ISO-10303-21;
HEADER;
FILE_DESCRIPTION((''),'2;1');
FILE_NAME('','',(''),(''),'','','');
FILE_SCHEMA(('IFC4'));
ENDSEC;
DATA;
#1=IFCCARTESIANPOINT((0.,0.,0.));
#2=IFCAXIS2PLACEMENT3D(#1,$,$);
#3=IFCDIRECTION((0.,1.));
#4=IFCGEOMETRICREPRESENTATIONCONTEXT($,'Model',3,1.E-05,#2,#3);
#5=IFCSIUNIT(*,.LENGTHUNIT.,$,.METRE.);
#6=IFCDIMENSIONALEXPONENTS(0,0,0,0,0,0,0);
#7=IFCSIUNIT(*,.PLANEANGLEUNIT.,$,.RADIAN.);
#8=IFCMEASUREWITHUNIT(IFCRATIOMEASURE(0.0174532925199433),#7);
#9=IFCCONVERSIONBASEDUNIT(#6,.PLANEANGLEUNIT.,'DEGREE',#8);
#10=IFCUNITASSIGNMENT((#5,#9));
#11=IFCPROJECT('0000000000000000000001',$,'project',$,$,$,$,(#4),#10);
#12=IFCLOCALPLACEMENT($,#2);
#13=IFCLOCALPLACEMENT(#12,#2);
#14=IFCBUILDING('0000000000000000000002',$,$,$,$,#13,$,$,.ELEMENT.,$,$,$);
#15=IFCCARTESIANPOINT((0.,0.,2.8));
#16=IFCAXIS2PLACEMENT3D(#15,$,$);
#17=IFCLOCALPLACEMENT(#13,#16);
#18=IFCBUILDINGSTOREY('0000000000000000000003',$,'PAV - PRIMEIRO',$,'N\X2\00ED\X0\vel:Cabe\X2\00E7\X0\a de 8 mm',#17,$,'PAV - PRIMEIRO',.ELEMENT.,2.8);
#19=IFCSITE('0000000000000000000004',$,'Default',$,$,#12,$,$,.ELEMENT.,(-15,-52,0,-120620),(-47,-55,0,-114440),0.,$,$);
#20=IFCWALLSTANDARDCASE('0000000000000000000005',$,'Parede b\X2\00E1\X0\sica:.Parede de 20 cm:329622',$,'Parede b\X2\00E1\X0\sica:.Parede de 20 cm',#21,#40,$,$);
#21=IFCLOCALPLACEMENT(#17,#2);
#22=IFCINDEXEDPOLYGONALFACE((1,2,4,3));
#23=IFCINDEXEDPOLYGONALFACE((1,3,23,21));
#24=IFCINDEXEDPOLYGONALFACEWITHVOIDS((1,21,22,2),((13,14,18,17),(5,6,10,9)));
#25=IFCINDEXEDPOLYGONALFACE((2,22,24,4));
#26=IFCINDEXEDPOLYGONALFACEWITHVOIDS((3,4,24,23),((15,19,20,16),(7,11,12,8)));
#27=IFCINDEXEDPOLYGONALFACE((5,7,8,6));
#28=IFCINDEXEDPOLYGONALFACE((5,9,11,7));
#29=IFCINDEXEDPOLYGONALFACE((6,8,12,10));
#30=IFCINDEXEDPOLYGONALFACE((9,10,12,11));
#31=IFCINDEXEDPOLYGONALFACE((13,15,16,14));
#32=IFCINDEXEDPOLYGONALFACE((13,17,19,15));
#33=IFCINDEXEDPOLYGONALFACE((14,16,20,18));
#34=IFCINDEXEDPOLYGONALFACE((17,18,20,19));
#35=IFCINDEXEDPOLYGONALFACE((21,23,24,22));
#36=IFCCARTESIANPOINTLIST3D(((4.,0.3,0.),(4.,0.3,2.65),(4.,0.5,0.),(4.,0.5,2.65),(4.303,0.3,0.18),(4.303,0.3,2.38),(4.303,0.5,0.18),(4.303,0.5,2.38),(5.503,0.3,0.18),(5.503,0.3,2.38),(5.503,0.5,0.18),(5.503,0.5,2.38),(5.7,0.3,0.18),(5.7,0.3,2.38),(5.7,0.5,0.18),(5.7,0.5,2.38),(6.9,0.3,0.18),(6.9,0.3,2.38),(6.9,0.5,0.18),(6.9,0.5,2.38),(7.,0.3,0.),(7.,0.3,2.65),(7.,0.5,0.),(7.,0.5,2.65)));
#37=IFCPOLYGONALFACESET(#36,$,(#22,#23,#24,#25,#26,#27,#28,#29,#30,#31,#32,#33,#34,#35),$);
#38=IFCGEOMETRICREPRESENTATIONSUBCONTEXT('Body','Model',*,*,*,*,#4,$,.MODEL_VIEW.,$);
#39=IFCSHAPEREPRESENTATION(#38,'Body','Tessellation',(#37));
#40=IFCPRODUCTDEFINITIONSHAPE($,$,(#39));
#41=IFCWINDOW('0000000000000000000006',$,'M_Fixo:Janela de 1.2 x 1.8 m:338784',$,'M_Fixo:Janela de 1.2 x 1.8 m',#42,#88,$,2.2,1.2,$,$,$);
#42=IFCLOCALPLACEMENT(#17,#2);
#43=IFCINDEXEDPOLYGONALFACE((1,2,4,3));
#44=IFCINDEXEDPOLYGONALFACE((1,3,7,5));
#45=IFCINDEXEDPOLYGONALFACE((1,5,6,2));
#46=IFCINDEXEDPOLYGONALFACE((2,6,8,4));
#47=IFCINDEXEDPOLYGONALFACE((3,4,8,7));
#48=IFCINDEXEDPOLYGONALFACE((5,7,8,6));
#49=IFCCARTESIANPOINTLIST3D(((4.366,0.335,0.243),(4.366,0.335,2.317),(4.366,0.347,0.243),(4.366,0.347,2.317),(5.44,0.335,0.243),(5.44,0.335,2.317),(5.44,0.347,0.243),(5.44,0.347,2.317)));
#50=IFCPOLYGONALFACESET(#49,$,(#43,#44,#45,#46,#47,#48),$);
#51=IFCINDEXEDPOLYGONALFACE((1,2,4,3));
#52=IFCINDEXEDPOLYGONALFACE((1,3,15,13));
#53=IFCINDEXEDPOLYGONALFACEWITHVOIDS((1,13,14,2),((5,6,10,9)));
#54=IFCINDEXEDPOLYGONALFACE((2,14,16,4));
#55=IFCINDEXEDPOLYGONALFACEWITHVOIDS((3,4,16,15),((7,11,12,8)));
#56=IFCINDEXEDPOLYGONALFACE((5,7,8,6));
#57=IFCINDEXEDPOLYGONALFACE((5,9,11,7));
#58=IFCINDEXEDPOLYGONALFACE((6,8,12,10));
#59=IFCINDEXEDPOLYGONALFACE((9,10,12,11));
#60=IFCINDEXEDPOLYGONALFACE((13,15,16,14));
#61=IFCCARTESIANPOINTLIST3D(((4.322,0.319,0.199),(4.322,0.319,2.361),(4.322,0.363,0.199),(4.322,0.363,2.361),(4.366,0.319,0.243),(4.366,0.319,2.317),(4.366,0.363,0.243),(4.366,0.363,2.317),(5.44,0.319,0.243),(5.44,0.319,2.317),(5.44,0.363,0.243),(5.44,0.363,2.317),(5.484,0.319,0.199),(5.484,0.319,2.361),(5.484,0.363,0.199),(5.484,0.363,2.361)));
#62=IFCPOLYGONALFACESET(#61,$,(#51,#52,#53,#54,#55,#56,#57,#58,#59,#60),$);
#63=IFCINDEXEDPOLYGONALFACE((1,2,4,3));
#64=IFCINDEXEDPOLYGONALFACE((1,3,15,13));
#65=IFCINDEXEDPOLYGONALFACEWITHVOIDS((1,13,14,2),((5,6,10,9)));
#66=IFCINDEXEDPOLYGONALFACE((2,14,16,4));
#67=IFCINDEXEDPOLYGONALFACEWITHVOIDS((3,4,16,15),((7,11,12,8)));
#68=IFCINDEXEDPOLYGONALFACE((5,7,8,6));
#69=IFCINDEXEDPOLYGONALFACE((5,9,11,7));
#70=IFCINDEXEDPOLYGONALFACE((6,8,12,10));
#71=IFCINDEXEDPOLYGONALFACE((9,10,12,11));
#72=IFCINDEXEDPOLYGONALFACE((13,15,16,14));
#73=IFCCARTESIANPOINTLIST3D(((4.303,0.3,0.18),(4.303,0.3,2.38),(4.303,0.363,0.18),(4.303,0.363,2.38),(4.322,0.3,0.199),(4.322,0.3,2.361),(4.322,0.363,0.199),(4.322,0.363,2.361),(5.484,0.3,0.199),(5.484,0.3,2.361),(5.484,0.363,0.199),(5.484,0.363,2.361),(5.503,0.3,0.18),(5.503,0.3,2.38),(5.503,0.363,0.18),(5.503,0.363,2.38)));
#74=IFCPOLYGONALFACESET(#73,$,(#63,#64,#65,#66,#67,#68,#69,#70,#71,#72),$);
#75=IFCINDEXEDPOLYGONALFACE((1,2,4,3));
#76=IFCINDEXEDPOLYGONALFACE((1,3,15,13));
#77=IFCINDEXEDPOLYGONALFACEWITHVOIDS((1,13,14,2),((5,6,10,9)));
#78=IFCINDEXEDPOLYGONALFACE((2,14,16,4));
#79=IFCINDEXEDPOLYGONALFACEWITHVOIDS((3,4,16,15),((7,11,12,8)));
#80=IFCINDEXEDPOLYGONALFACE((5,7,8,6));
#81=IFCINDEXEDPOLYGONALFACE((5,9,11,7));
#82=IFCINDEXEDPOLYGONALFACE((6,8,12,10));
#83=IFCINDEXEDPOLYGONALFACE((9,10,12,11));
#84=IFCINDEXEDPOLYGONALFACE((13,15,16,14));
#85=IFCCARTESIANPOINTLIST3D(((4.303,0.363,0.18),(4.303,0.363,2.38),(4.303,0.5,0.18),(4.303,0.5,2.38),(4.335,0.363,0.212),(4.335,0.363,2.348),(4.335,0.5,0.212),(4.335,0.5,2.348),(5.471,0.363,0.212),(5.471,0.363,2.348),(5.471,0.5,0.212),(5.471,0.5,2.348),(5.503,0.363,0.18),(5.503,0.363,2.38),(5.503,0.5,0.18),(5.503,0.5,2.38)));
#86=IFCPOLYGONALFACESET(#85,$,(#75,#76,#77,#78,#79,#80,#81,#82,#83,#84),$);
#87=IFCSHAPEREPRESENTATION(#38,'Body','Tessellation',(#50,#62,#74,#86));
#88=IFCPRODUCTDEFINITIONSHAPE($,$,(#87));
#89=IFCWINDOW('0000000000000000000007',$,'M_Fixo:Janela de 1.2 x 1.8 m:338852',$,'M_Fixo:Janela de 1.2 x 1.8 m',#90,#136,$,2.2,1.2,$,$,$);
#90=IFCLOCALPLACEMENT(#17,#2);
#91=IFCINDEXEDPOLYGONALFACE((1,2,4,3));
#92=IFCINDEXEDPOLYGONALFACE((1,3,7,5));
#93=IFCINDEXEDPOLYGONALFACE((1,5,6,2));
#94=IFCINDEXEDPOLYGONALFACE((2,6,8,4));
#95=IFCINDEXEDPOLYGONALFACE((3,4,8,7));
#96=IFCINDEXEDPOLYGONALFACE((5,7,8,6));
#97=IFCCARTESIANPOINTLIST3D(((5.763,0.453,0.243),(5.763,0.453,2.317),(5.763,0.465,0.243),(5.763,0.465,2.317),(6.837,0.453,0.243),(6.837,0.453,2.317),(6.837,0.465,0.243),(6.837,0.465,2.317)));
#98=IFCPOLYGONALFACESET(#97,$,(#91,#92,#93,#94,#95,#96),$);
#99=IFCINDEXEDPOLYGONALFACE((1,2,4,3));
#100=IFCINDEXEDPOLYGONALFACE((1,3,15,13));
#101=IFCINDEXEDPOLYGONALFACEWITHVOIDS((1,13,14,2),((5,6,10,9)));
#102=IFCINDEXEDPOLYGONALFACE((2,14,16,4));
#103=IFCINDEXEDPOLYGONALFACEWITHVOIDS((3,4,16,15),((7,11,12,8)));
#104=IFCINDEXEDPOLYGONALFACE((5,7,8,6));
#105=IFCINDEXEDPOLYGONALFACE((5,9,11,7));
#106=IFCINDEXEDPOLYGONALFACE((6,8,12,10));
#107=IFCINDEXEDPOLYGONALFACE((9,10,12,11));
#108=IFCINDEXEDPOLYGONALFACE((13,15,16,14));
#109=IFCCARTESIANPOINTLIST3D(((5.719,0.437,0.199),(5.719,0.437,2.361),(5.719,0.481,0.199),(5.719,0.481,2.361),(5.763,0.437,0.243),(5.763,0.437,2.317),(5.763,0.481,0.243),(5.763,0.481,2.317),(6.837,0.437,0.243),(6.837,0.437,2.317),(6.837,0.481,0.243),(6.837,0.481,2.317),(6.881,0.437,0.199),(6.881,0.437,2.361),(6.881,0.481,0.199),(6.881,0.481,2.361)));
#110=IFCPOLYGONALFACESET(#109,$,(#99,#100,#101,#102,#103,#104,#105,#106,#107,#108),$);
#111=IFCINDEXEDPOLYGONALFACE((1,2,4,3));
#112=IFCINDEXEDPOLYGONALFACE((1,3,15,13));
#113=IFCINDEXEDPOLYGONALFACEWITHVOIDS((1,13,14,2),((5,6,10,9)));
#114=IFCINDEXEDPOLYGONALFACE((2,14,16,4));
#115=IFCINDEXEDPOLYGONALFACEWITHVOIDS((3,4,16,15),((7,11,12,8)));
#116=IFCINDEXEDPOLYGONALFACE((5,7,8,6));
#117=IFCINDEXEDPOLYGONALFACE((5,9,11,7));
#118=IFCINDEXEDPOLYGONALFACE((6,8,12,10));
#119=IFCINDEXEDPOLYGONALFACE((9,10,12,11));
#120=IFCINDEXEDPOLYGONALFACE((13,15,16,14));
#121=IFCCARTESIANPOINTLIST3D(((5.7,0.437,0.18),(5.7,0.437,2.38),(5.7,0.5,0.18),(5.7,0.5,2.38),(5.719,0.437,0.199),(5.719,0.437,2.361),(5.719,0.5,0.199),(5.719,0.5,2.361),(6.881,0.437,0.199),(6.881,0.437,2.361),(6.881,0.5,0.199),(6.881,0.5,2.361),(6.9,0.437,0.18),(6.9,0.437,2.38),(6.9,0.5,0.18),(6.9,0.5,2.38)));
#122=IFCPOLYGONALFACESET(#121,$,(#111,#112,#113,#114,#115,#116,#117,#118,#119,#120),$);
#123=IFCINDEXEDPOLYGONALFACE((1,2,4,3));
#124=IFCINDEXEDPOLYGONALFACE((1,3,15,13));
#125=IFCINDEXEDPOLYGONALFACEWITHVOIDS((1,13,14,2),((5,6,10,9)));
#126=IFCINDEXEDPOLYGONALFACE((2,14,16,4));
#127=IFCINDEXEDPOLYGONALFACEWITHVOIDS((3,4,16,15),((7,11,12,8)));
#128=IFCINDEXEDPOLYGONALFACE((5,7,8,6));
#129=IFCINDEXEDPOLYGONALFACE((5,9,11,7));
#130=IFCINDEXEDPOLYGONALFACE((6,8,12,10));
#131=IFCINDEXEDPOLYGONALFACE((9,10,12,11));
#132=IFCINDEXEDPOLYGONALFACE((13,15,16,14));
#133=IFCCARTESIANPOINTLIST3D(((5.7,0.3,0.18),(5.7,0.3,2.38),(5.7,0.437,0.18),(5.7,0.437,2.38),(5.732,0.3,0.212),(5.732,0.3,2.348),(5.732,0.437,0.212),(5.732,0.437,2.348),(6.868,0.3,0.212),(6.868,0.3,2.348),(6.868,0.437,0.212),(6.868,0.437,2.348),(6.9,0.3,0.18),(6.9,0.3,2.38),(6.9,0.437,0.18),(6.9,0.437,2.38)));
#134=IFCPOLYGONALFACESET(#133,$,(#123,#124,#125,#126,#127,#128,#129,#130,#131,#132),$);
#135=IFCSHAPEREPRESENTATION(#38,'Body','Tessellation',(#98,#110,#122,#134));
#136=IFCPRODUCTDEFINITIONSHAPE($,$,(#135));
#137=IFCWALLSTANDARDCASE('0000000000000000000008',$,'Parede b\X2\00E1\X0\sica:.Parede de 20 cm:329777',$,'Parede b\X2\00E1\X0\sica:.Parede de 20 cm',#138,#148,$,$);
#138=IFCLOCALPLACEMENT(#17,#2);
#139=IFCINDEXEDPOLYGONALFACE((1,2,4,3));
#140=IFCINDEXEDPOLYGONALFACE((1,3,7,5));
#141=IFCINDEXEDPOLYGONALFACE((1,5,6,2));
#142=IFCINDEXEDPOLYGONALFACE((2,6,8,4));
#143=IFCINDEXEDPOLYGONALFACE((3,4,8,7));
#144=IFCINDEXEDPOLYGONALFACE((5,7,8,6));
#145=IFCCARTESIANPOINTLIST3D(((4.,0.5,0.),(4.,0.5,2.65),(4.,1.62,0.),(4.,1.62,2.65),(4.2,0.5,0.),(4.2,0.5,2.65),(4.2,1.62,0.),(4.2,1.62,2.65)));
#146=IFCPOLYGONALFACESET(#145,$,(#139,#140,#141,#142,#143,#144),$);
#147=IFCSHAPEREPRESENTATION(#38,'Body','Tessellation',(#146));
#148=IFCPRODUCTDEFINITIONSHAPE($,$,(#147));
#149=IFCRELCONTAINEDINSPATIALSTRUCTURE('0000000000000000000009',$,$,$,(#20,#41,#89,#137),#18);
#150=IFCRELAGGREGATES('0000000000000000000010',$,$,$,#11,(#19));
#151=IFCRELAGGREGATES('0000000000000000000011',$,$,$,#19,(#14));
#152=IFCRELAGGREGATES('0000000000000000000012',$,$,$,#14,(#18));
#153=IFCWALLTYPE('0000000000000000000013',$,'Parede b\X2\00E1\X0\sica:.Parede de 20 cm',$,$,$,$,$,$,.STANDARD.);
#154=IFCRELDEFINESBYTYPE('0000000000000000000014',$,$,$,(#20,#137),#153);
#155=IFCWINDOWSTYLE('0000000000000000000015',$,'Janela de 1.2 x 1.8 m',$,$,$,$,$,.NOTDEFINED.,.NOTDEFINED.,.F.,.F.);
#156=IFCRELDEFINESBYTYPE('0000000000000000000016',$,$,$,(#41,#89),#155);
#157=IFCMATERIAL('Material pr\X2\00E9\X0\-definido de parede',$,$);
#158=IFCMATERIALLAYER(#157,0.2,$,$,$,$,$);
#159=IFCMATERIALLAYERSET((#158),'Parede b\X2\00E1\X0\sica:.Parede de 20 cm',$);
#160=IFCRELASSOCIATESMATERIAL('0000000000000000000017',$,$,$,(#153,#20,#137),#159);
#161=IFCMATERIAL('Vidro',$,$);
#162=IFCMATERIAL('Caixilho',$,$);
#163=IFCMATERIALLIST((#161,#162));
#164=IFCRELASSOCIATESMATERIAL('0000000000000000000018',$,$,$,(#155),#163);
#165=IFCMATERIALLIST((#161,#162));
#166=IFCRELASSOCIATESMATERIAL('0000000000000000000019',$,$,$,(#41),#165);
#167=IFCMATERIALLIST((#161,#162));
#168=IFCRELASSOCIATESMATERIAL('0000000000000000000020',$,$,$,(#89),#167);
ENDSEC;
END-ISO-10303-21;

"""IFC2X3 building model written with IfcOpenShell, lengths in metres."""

from ifc_helpers import new_model, entity, si_unit, converted_unit, direction, frame, frame_2d, origin, place, context, subcontext, project, spatial, polyline, rectangle, outline, extrude, clip, bounded_halfspace, source, transform, mapped, material, material_list, layer, layer_set, layer_usage, type_object, type_shapes, element, fill, save


model = new_model("IFC2X3")

# Units and contexts
model_context = context("Model", 3, precision=1e-05, world=origin(), true_north=direction((0.0, 1.0)))
body_context = subcontext(model_context, "Body", "Model", "MODEL_VIEW")
ifc_project = project(units=[si_unit("LENGTHUNIT", "METRE"), converted_unit("PLANEANGLEUNIT", "DEGREE", entity("IfcRatioMeasure", 0.0174532925199433), si_unit("PLANEANGLEUNIT", "RADIAN"), dimensions=[0, 0, 0, 0, 0, 0, 0])], contexts=[model_context])

# Site, building, storey
site_placement = place(None, origin())
site = spatial("IfcSite", under=ifc_project, at=site_placement, Name="Default", CompositionType="ELEMENT", RefLatitude=(-15, -52, 0, -120620), RefLongitude=(-47, -55, 0, -114440), RefElevation=0.0)
building_placement = place(site_placement, origin())
building = spatial("IfcBuilding", under=site, at=building_placement, CompositionType="ELEMENT")
storey_placement = place(building_placement, frame((0.0, 0.0, 2.8)))
storey = spatial("IfcBuildingStorey", under=building, at=storey_placement, Name="PAV - PRIMEIRO", ObjectType="Nível:Cabeça de 8 mm", LongName="PAV - PRIMEIRO", CompositionType="ELEMENT", Elevation=2.8)

# Shared definitions
ifc_material_1 = material(Name="Material pré-definido de parede")
ifc_layer_1 = layer(ifc_material_1, 0.2)
ifc_layer_set_1 = layer_set([ifc_layer_1], Name="Parede básica:.Parede de 20 cm")
wall_type_1 = type_object("IfcWallType", Name="Parede básica:.Parede de 20 cm", PredefinedType="STANDARD", material=ifc_layer_set_1)

# Shared definitions
ifc_material_2 = material(Name="Vidro")

# Wall, openings, windows
ifc_layer_usage_1 = layer_usage(ifc_layer_set_1, "AXIS2", "NEGATIVE", 0.1)
wall_1_placement = place(storey_placement, frame((7.0, 0.4, 0.0), z_axis=(0.0, 0.0, 1.0), x_axis=(-1.0, 0.0, 0.0)))
wall_1 = element("IfcWallStandardCase", 1, at=wall_1_placement, inside=storey, type_object=wall_type_1, material=ifc_layer_usage_1, Name="Parede básica:.Parede de 20 cm:329622", ObjectType="Parede básica:.Parede de 20 cm", context=body_context, shape_type="Clipping", body=[
    clip(extrude(rectangle(XDim=3.0, YDim=0.2, at=frame_2d((1.5, 0.0), x_axis=(-1.0, 0.0))), origin(), (0.0, 0.0, 1.0), 2.65), bounded_halfspace(frame((0.0, -0.1, 2.65), z_axis=(0.0, 0.0, -1.0), x_axis=(0.0, 1.0, 0.0)), True, frame((0.0, -0.1, 2.65)), polyline([(0.0, 0.0), (2.8, 0.0), (3.0, 0.0), (3.0, 0.2), (0.0, 0.2), (0.0, 0.0)]))),
])
opening_1_placement = place(wall_1_placement, frame((1.3, 0.1, 0.18)))
opening_1 = element("IfcOpeningElement", 2, at=opening_1_placement, cuts=wall_1, ObjectType="Opening", context=body_context, shape_type="SweptSolid", body=[
    extrude(rectangle(XDim=2.2, YDim=1.2, at=frame_2d((1.1, 0.6), x_axis=(1.0, 0.0))), frame((0.0, 0.0, 0.0), z_axis=(0.0, -1.0, 0.0), x_axis=(0.0, 0.0, 1.0)), (0.0, 0.0, 1.0), 0.2),
])
opening_2_placement = place(wall_1_placement, frame((1.497, -0.1, 0.18)))
opening_2 = element("IfcOpeningElement", 3, at=opening_2_placement, cuts=wall_1, ObjectType="Opening", context=body_context, shape_type="SweptSolid", body=[
    extrude(rectangle(XDim=2.2, YDim=1.2, at=frame_2d((1.1, 0.6), x_axis=(1.0, 0.0))), frame((0.0, 0.0, 0.0), z_axis=(0.0, 1.0, 0.0), x_axis=(0.0, 0.0, 1.0)), (0.0, 0.0, 1.0), 0.2),
])
ifc_material_3 = material(Name="Caixilho")
ifc_material_list_1 = material_list([ifc_material_2, ifc_material_3])
ifc_material_list_2 = material_list([ifc_material_2, ifc_material_3])
window_style_1 = type_object("IfcWindowStyle", Name="Janela de 1.2 x 1.8 m", ConstructionType="NOTDEFINED", OperationType="NOTDEFINED", ParameterTakesPrecedence=False, Sizeable=False, material=ifc_material_list_2)
shared_shape_1 = source(origin(), body_context, "Body", "SweptSolid", [
    extrude(rectangle(XDim=0.012, YDim=1.074, at=frame_2d((0.0, 0.0), x_axis=(1.0, 0.0))), frame((0.6, 0.159, 0.063), z_axis=(0.0, 0.0, 1.0), x_axis=(0.0, -1.0, 0.0)), (0.0, 0.0, 1.0), 2.074),
    extrude(outline(polyline([(-0.581, -1.081), (0.581, -1.081), (0.581, 1.081), (-0.581, 1.081), (-0.581, -1.081)]), holes=[polyline([(-0.537, -1.037), (-0.537, 1.037), (0.537, 1.037), (0.537, -1.037), (-0.537, -1.037)])]), frame((0.6, 0.137, 1.1), z_axis=(0.0, 1.0, 0.0), x_axis=(1.0, 0.0, 0.0)), (0.0, 0.0, 1.0), 0.044),
    extrude(outline(polyline([(-0.6, -1.1), (0.6, -1.1), (0.6, 1.1), (-0.6, 1.1), (-0.6, -1.1)]), holes=[polyline([(-0.581, -1.081), (-0.581, 1.081), (0.581, 1.081), (0.581, -1.081), (-0.581, -1.081)])]), frame((0.6, 0.137, 1.1), z_axis=(0.0, 1.0, 0.0), x_axis=(1.0, 0.0, 0.0)), (0.0, 0.0, 1.0), 0.063),
    extrude(outline(polyline([(-0.6, -1.1), (0.6, -1.1), (0.6, 1.1), (-0.6, 1.1), (-0.6, -1.1)]), holes=[polyline([(-0.568, -1.068), (-0.568, 1.068), (0.568, 1.068), (0.568, -1.068), (-0.568, -1.068)])]), frame((0.6, 0.0, 1.1), z_axis=(0.0, 1.0, 0.0), x_axis=(1.0, 0.0, 0.0)), (0.0, 0.0, 1.0), 0.137),
])
type_shapes(window_style_1, [shared_shape_1])
window_1_placement = place(opening_2_placement, origin())
window_1 = element("IfcWindow", 4, at=window_1_placement, inside=storey, type_object=window_style_1, material=ifc_material_list_1, Name="M_Fixo:Janela de 1.2 x 1.8 m:338784", ObjectType="M_Fixo:Janela de 1.2 x 1.8 m", OverallHeight=2.2, OverallWidth=1.2, context=body_context, shape_type="MappedRepresentation", body=[
    mapped(shared_shape_1, transform((0.0, 0.0, 0.0), scale=1.0)),
])
fill(opening_2, window_1)
ifc_material_list_3 = material_list([ifc_material_2, ifc_material_3])
window_2_placement = place(opening_1_placement, frame((0.0, 0.0, 0.0), z_axis=(0.0, 0.0, 1.0), x_axis=(-1.0, 0.0, 0.0)))
window_2 = element("IfcWindow", 5, at=window_2_placement, inside=storey, type_object=window_style_1, material=ifc_material_list_3, Name="M_Fixo:Janela de 1.2 x 1.8 m:338852", ObjectType="M_Fixo:Janela de 1.2 x 1.8 m", OverallHeight=2.2, OverallWidth=1.2, context=body_context, shape_type="MappedRepresentation", body=[
    mapped(shared_shape_1, transform((0.0, 0.0, 0.0), scale=1.0)),
])
fill(opening_1, window_2)

# Wall
ifc_layer_usage_2 = layer_usage(ifc_layer_set_1, "AXIS2", "NEGATIVE", 0.1)
wall_2_placement = place(storey_placement, frame((4.1, 0.5, 0.0), z_axis=(0.0, 0.0, 1.0), x_axis=(0.0, 1.0, 0.0)))
element("IfcWallStandardCase", 6, at=wall_2_placement, inside=storey, type_object=wall_type_1, material=ifc_layer_usage_2, Name="Parede básica:.Parede de 20 cm:329777", ObjectType="Parede básica:.Parede de 20 cm", context=body_context, shape_type="Clipping", body=[
    clip(extrude(rectangle(XDim=1.12, YDim=0.2, at=frame_2d((0.56, 0.0), x_axis=(-1.0, 0.0))), origin(), (0.0, 0.0, 1.0), 2.65), bounded_halfspace(frame((0.0, -0.1, 2.65), z_axis=(0.0, 0.0, -1.0), x_axis=(-1.0, 0.0, 0.0)), True, frame((0.0, -0.1, 2.65)), polyline([(0.0, 0.0), (1.12, 0.0), (1.12, 0.2), (0.92, 0.2), (0.0, 0.2), (0.0, 0.0)]))),
])

save(model, "model.ifc")
